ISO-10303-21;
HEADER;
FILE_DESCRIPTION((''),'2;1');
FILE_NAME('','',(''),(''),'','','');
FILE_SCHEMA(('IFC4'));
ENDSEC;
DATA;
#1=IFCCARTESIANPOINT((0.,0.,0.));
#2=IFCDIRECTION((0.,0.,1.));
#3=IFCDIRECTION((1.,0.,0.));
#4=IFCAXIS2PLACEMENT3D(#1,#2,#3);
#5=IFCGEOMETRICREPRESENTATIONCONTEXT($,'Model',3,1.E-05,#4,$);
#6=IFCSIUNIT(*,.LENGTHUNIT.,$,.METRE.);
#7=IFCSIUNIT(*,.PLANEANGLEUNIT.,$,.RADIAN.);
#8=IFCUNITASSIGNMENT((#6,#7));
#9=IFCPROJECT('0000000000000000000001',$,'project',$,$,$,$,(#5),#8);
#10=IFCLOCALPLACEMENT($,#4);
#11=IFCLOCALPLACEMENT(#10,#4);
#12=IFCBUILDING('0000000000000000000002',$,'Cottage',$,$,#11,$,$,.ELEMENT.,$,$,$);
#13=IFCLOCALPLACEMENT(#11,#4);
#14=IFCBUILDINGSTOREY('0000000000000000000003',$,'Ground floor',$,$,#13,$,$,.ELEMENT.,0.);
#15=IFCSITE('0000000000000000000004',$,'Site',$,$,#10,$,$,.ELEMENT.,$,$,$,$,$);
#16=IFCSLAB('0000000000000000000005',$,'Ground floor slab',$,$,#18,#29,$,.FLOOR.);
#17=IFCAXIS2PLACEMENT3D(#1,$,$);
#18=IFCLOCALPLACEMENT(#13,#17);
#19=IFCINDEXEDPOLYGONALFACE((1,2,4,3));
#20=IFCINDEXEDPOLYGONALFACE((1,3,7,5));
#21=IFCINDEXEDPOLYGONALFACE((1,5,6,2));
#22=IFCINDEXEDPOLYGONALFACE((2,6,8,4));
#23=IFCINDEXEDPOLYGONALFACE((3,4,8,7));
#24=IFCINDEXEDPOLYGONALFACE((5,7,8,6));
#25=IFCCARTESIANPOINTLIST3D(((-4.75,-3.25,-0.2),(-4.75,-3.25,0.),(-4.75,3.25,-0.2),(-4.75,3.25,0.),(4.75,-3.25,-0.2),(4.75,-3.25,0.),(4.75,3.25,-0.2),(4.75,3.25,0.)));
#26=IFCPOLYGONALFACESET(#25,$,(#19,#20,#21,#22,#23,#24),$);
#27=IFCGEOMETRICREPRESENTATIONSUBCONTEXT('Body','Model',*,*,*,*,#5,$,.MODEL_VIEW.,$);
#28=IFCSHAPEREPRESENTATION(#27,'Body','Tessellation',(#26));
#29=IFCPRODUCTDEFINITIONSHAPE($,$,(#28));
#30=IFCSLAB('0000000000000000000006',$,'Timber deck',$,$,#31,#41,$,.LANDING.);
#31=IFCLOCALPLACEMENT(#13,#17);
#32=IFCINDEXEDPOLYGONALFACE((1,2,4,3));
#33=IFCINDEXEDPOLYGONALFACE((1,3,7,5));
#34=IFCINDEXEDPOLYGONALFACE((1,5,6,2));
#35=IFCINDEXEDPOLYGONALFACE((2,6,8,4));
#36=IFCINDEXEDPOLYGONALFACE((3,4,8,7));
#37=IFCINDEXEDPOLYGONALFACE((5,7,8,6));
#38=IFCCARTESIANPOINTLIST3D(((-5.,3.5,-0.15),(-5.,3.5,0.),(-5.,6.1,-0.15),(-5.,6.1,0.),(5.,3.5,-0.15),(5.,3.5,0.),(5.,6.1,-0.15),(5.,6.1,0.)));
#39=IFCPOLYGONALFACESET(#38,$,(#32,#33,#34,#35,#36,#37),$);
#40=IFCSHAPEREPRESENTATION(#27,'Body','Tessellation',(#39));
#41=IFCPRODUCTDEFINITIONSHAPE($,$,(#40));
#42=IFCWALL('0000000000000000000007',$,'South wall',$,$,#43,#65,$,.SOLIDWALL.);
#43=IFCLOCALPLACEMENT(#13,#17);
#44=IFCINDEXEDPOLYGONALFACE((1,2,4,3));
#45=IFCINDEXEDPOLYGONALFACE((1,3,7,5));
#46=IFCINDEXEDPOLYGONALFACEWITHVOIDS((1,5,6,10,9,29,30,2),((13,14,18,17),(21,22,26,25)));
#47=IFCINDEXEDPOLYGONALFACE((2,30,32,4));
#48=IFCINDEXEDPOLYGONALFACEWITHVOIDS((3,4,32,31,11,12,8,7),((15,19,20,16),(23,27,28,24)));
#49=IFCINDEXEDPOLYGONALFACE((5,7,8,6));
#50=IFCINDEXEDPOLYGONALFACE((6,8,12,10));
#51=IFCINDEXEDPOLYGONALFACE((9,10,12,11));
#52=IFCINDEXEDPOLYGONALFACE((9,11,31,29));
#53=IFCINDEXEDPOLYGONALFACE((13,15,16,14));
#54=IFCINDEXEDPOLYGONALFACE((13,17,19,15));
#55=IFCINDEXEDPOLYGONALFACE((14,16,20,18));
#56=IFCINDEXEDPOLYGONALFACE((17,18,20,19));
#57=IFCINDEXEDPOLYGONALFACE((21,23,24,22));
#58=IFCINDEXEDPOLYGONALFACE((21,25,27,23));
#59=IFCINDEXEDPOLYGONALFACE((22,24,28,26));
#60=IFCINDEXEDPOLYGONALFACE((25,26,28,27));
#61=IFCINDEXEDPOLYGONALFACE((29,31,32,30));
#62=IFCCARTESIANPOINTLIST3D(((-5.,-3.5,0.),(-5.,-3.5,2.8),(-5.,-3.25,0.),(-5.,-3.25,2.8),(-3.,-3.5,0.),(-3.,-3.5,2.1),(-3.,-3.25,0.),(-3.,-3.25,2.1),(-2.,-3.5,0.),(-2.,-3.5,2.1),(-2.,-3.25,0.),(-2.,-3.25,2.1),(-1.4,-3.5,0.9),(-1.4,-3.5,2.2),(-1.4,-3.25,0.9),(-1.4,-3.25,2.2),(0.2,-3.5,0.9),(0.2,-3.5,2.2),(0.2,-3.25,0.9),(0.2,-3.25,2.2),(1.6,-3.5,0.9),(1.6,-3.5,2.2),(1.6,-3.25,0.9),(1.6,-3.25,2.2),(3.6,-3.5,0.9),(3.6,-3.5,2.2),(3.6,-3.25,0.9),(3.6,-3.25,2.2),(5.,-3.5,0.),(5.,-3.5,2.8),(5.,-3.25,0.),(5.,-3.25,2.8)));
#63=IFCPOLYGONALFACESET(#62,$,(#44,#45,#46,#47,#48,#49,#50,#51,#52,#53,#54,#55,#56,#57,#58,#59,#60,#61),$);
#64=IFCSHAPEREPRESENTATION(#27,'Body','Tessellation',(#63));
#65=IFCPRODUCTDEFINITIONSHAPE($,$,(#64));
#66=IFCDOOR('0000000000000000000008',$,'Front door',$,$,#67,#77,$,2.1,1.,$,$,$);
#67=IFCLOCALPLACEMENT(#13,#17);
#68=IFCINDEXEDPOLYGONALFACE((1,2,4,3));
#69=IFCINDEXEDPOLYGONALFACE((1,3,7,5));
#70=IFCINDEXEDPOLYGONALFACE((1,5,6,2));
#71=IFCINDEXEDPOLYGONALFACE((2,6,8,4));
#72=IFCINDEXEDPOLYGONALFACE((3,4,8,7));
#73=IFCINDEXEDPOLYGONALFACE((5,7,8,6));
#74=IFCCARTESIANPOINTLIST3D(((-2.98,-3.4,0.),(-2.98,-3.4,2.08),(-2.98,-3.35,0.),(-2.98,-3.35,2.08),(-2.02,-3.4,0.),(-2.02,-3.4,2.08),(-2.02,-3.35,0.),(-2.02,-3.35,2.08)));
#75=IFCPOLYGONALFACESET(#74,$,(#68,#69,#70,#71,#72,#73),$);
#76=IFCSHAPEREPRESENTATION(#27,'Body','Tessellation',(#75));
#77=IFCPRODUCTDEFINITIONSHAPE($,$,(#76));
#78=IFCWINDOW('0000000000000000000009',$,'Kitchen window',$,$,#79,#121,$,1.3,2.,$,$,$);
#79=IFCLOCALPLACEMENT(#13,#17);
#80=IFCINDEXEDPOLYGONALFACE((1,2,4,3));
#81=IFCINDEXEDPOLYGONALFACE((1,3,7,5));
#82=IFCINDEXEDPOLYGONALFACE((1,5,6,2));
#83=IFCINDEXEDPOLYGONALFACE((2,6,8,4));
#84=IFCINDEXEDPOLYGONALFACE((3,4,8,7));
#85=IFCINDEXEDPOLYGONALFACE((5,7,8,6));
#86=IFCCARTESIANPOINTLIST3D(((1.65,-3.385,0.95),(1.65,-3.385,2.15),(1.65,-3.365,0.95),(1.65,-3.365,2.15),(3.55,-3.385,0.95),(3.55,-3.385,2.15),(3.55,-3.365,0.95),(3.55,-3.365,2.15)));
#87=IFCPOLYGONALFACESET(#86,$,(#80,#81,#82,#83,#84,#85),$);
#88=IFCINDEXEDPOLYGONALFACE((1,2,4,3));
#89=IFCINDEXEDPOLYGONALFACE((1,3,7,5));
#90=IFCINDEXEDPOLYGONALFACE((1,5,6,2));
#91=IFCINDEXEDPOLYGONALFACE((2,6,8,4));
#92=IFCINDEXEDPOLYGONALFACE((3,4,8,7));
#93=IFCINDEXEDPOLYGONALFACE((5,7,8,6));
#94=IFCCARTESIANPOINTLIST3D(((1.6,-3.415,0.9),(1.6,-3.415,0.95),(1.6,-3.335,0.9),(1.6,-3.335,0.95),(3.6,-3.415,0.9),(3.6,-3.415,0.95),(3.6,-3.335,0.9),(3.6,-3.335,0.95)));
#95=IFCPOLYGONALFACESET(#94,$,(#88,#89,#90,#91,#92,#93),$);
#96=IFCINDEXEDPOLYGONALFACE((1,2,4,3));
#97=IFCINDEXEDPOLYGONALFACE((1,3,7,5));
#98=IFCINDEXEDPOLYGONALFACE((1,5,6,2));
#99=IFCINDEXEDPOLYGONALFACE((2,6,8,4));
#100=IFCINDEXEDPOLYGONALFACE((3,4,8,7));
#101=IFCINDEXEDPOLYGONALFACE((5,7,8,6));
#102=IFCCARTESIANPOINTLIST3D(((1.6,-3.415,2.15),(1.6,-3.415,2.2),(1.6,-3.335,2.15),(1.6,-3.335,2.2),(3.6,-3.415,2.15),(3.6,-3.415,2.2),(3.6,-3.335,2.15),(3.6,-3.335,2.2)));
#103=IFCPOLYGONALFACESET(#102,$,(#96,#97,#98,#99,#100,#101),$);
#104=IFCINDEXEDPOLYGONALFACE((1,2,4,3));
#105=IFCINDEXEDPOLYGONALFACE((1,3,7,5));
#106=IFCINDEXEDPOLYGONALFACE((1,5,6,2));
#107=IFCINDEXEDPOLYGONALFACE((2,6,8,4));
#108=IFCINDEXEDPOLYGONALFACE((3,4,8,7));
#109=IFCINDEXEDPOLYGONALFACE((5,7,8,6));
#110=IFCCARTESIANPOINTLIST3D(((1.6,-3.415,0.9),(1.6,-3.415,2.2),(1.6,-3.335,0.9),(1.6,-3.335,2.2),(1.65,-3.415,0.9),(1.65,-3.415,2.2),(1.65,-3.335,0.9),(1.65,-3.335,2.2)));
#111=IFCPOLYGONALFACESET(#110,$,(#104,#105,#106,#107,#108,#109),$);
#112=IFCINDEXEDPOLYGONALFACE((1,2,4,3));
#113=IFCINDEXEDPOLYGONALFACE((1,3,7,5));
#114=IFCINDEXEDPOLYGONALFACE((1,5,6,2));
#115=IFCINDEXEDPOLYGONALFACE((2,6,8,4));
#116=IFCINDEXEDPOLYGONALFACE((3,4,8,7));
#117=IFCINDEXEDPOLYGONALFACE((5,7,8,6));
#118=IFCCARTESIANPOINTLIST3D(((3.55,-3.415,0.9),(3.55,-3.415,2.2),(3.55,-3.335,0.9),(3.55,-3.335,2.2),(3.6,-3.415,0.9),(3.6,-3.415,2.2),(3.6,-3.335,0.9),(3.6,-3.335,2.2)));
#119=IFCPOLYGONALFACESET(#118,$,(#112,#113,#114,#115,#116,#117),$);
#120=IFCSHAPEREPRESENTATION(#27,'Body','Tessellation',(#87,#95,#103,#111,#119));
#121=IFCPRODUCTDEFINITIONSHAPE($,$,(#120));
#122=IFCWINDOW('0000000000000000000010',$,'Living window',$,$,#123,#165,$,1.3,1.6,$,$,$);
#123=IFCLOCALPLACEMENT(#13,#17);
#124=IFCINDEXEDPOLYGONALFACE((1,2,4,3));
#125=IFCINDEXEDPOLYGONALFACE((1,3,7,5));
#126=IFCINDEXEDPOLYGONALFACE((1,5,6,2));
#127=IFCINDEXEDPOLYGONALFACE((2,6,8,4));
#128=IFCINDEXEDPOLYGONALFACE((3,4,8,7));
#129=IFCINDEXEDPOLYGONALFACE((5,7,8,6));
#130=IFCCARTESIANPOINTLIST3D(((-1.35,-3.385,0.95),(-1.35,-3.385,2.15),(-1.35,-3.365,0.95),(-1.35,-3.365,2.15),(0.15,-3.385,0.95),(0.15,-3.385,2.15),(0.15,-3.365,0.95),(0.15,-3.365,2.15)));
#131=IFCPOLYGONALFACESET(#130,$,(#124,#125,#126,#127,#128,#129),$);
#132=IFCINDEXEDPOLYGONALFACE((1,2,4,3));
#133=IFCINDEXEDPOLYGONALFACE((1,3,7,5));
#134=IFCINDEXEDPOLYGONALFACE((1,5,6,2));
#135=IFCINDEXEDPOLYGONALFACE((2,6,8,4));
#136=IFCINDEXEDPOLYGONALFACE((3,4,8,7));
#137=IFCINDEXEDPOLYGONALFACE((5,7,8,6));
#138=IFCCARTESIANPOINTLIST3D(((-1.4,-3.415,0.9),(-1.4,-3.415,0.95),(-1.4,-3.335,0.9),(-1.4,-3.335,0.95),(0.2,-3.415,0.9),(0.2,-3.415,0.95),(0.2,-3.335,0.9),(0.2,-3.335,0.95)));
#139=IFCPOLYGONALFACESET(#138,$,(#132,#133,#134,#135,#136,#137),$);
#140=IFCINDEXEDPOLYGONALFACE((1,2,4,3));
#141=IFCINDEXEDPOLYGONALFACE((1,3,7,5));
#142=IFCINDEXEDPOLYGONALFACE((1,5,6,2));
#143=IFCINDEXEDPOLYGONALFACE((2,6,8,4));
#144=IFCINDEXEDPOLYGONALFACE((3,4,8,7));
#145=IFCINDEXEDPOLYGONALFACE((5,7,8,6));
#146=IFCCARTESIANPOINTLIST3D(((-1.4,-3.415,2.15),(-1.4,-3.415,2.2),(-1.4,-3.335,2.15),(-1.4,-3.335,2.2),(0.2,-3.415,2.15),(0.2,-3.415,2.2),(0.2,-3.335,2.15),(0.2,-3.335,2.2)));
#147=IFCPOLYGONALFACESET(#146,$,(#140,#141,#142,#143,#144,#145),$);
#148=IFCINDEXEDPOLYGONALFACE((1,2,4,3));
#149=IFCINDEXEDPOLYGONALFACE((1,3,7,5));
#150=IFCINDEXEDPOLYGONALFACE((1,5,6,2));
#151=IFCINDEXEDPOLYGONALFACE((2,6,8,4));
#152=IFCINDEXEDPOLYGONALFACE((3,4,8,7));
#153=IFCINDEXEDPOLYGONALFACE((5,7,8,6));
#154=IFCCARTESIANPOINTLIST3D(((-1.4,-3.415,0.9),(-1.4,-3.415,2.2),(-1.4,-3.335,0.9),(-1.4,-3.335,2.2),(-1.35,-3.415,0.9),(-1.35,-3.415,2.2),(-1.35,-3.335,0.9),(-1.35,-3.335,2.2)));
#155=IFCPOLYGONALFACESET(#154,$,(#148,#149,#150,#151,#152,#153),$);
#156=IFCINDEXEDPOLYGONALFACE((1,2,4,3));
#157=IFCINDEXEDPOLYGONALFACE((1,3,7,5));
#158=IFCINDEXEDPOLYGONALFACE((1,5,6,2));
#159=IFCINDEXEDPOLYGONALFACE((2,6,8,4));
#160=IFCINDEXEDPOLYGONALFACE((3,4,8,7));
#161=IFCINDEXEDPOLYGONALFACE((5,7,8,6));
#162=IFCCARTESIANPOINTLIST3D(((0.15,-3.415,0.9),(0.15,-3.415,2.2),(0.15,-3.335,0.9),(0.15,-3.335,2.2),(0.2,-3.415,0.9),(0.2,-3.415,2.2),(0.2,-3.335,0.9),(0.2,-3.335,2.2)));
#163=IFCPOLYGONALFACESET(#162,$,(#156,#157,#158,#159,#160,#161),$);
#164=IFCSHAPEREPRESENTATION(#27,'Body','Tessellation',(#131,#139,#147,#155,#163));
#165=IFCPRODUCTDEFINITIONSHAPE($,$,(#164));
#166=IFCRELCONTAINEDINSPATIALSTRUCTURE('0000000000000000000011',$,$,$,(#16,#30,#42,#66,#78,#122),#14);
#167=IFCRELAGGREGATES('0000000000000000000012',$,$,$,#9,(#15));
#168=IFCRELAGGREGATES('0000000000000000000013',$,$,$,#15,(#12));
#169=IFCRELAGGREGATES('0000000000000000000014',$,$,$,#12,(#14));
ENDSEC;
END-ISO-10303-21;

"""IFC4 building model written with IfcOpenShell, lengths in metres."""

from ifc_helpers import new_model, si_unit, frame, frame_2d, origin_with_axes, origin_2d, place, context, subcontext, project, spatial, rectangle, extrude, element, fill, save


model = new_model("IFC4")

# Units and contexts
model_context = context("Model", 3, precision=1e-05, world=origin_with_axes())
body_context = subcontext(model_context, "Body", "Model", "MODEL_VIEW")
ifc_project = project(units=[si_unit("LENGTHUNIT", "METRE"), si_unit("PLANEANGLEUNIT", "RADIAN")], contexts=[model_context])

# Site, building, storey
site_placement = place(None, origin_with_axes())
site = spatial("IfcSite", under=ifc_project, at=site_placement, Name="Site", CompositionType="ELEMENT")
building_placement = place(site_placement, origin_with_axes())
building = spatial("IfcBuilding", under=site, at=building_placement, Name="Cottage", CompositionType="ELEMENT")
storey_placement = place(building_placement, origin_with_axes())
storey = spatial("IfcBuildingStorey", under=building, at=storey_placement, Name="Ground floor", CompositionType="ELEMENT", Elevation=0.0)

# Slabs
slab_1_placement = place(storey_placement, origin_with_axes())
element("IfcSlab", 1, at=slab_1_placement, inside=storey, Name="Ground floor slab", PredefinedType="FLOOR", context=body_context, shape_type="SweptSolid", body=[
    extrude(rectangle(XDim=9.5, YDim=6.5, at=origin_2d()), frame((0.0, 0.0, -0.2), z_axis=(0.0, 0.0, 1.0), x_axis=(1.0, 0.0, 0.0)), (0.0, 0.0, 1.0), 0.2),
])
slab_2_placement = place(storey_placement, origin_with_axes())
element("IfcSlab", 2, at=slab_2_placement, inside=storey, Name="Timber deck", PredefinedType="LANDING", context=body_context, shape_type="SweptSolid", body=[
    extrude(rectangle(XDim=10.0, YDim=2.6, at=frame_2d((0.0, 4.8))), frame((0.0, 0.0, -0.15), z_axis=(0.0, 0.0, 1.0), x_axis=(1.0, 0.0, 0.0)), (0.0, 0.0, 1.0), 0.15),
])

# Wall, openings, door, windows
wall_1_placement = place(storey_placement, origin_with_axes())
wall_1 = element("IfcWall", 3, at=wall_1_placement, inside=storey, Name="South wall", PredefinedType="SOLIDWALL", context=body_context, shape_type="SweptSolid", body=[
    extrude(rectangle(XDim=10.0, YDim=0.25, at=frame_2d((0.0, -3.375))), origin_with_axes(), (0.0, 0.0, 1.0), 2.8),
])
opening_1_placement = place(storey_placement, origin_with_axes())
opening_1 = element("IfcOpeningElement", 4, at=opening_1_placement, cuts=wall_1, PredefinedType="OPENING", context=body_context, shape_type="SweptSolid", body=[
    extrude(rectangle(XDim=1.0, YDim=0.45, at=frame_2d((-2.5, -3.375))), origin_with_axes(), (0.0, 0.0, 1.0), 2.1),
])
opening_2_placement = place(storey_placement, origin_with_axes())
opening_2 = element("IfcOpeningElement", 5, at=opening_2_placement, cuts=wall_1, PredefinedType="OPENING", context=body_context, shape_type="SweptSolid", body=[
    extrude(rectangle(XDim=2.0, YDim=0.45, at=frame_2d((2.6, -3.375))), frame((0.0, 0.0, 0.9), z_axis=(0.0, 0.0, 1.0), x_axis=(1.0, 0.0, 0.0)), (0.0, 0.0, 1.0), 1.3),
])
opening_3_placement = place(storey_placement, origin_with_axes())
opening_3 = element("IfcOpeningElement", 6, at=opening_3_placement, cuts=wall_1, PredefinedType="OPENING", context=body_context, shape_type="SweptSolid", body=[
    extrude(rectangle(XDim=1.6, YDim=0.45, at=frame_2d((-0.6, -3.375))), frame((0.0, 0.0, 0.9), z_axis=(0.0, 0.0, 1.0), x_axis=(1.0, 0.0, 0.0)), (0.0, 0.0, 1.0), 1.3),
])
door_1_placement = place(storey_placement, origin_with_axes())
door_1 = element("IfcDoor", 7, at=door_1_placement, inside=storey, Name="Front door", OverallHeight=2.1, OverallWidth=1.0, context=body_context, shape_type="SweptSolid", body=[
    extrude(rectangle(XDim=0.96, YDim=0.05, at=frame_2d((-2.5, -3.375))), origin_with_axes(), (0.0, 0.0, 1.0), 2.08),
])
fill(opening_1, door_1)
window_1_placement = place(storey_placement, origin_with_axes())
window_1 = element("IfcWindow", 8, at=window_1_placement, inside=storey, Name="Kitchen window", OverallHeight=1.3, OverallWidth=2.0, context=body_context, shape_type="SweptSolid", body=[
    extrude(rectangle(XDim=1.9, YDim=0.02, at=frame_2d((2.6, -3.375))), frame((0.0, 0.0, 0.95), z_axis=(0.0, 0.0, 1.0), x_axis=(1.0, 0.0, 0.0)), (0.0, 0.0, 1.0), 1.2),
    extrude(rectangle(XDim=2.0, YDim=0.08, at=frame_2d((2.6, -3.375))), frame((0.0, 0.0, 0.9), z_axis=(0.0, 0.0, 1.0), x_axis=(1.0, 0.0, 0.0)), (0.0, 0.0, 1.0), 0.05),
    extrude(rectangle(XDim=2.0, YDim=0.08, at=frame_2d((2.6, -3.375))), frame((0.0, 0.0, 2.15), z_axis=(0.0, 0.0, 1.0), x_axis=(1.0, 0.0, 0.0)), (0.0, 0.0, 1.0), 0.05),
    extrude(rectangle(XDim=0.05, YDim=0.08, at=frame_2d((1.625, -3.375))), frame((0.0, 0.0, 0.9), z_axis=(0.0, 0.0, 1.0), x_axis=(1.0, 0.0, 0.0)), (0.0, 0.0, 1.0), 1.3),
    extrude(rectangle(XDim=0.05, YDim=0.08, at=frame_2d((3.575, -3.375))), frame((0.0, 0.0, 0.9), z_axis=(0.0, 0.0, 1.0), x_axis=(1.0, 0.0, 0.0)), (0.0, 0.0, 1.0), 1.3),
])
fill(opening_2, window_1)
window_2_placement = place(storey_placement, origin_with_axes())
window_2 = element("IfcWindow", 9, at=window_2_placement, inside=storey, Name="Living window", OverallHeight=1.3, OverallWidth=1.6, context=body_context, shape_type="SweptSolid", body=[
    extrude(rectangle(XDim=1.5, YDim=0.02, at=frame_2d((-0.6, -3.375))), frame((0.0, 0.0, 0.95), z_axis=(0.0, 0.0, 1.0), x_axis=(1.0, 0.0, 0.0)), (0.0, 0.0, 1.0), 1.2),
    extrude(rectangle(XDim=1.6, YDim=0.08, at=frame_2d((-0.6, -3.375))), frame((0.0, 0.0, 0.9), z_axis=(0.0, 0.0, 1.0), x_axis=(1.0, 0.0, 0.0)), (0.0, 0.0, 1.0), 0.05),
    extrude(rectangle(XDim=1.6, YDim=0.08, at=frame_2d((-0.6, -3.375))), frame((0.0, 0.0, 2.15), z_axis=(0.0, 0.0, 1.0), x_axis=(1.0, 0.0, 0.0)), (0.0, 0.0, 1.0), 0.05),
    extrude(rectangle(XDim=0.05, YDim=0.08, at=frame_2d((-1.375, -3.375))), frame((0.0, 0.0, 0.9), z_axis=(0.0, 0.0, 1.0), x_axis=(1.0, 0.0, 0.0)), (0.0, 0.0, 1.0), 1.3),
    extrude(rectangle(XDim=0.05, YDim=0.08, at=frame_2d((0.175, -3.375))), frame((0.0, 0.0, 0.9), z_axis=(0.0, 0.0, 1.0), x_axis=(1.0, 0.0, 0.0)), (0.0, 0.0, 1.0), 1.3),
])
fill(opening_3, window_2)

save(model, "model.ifc")
